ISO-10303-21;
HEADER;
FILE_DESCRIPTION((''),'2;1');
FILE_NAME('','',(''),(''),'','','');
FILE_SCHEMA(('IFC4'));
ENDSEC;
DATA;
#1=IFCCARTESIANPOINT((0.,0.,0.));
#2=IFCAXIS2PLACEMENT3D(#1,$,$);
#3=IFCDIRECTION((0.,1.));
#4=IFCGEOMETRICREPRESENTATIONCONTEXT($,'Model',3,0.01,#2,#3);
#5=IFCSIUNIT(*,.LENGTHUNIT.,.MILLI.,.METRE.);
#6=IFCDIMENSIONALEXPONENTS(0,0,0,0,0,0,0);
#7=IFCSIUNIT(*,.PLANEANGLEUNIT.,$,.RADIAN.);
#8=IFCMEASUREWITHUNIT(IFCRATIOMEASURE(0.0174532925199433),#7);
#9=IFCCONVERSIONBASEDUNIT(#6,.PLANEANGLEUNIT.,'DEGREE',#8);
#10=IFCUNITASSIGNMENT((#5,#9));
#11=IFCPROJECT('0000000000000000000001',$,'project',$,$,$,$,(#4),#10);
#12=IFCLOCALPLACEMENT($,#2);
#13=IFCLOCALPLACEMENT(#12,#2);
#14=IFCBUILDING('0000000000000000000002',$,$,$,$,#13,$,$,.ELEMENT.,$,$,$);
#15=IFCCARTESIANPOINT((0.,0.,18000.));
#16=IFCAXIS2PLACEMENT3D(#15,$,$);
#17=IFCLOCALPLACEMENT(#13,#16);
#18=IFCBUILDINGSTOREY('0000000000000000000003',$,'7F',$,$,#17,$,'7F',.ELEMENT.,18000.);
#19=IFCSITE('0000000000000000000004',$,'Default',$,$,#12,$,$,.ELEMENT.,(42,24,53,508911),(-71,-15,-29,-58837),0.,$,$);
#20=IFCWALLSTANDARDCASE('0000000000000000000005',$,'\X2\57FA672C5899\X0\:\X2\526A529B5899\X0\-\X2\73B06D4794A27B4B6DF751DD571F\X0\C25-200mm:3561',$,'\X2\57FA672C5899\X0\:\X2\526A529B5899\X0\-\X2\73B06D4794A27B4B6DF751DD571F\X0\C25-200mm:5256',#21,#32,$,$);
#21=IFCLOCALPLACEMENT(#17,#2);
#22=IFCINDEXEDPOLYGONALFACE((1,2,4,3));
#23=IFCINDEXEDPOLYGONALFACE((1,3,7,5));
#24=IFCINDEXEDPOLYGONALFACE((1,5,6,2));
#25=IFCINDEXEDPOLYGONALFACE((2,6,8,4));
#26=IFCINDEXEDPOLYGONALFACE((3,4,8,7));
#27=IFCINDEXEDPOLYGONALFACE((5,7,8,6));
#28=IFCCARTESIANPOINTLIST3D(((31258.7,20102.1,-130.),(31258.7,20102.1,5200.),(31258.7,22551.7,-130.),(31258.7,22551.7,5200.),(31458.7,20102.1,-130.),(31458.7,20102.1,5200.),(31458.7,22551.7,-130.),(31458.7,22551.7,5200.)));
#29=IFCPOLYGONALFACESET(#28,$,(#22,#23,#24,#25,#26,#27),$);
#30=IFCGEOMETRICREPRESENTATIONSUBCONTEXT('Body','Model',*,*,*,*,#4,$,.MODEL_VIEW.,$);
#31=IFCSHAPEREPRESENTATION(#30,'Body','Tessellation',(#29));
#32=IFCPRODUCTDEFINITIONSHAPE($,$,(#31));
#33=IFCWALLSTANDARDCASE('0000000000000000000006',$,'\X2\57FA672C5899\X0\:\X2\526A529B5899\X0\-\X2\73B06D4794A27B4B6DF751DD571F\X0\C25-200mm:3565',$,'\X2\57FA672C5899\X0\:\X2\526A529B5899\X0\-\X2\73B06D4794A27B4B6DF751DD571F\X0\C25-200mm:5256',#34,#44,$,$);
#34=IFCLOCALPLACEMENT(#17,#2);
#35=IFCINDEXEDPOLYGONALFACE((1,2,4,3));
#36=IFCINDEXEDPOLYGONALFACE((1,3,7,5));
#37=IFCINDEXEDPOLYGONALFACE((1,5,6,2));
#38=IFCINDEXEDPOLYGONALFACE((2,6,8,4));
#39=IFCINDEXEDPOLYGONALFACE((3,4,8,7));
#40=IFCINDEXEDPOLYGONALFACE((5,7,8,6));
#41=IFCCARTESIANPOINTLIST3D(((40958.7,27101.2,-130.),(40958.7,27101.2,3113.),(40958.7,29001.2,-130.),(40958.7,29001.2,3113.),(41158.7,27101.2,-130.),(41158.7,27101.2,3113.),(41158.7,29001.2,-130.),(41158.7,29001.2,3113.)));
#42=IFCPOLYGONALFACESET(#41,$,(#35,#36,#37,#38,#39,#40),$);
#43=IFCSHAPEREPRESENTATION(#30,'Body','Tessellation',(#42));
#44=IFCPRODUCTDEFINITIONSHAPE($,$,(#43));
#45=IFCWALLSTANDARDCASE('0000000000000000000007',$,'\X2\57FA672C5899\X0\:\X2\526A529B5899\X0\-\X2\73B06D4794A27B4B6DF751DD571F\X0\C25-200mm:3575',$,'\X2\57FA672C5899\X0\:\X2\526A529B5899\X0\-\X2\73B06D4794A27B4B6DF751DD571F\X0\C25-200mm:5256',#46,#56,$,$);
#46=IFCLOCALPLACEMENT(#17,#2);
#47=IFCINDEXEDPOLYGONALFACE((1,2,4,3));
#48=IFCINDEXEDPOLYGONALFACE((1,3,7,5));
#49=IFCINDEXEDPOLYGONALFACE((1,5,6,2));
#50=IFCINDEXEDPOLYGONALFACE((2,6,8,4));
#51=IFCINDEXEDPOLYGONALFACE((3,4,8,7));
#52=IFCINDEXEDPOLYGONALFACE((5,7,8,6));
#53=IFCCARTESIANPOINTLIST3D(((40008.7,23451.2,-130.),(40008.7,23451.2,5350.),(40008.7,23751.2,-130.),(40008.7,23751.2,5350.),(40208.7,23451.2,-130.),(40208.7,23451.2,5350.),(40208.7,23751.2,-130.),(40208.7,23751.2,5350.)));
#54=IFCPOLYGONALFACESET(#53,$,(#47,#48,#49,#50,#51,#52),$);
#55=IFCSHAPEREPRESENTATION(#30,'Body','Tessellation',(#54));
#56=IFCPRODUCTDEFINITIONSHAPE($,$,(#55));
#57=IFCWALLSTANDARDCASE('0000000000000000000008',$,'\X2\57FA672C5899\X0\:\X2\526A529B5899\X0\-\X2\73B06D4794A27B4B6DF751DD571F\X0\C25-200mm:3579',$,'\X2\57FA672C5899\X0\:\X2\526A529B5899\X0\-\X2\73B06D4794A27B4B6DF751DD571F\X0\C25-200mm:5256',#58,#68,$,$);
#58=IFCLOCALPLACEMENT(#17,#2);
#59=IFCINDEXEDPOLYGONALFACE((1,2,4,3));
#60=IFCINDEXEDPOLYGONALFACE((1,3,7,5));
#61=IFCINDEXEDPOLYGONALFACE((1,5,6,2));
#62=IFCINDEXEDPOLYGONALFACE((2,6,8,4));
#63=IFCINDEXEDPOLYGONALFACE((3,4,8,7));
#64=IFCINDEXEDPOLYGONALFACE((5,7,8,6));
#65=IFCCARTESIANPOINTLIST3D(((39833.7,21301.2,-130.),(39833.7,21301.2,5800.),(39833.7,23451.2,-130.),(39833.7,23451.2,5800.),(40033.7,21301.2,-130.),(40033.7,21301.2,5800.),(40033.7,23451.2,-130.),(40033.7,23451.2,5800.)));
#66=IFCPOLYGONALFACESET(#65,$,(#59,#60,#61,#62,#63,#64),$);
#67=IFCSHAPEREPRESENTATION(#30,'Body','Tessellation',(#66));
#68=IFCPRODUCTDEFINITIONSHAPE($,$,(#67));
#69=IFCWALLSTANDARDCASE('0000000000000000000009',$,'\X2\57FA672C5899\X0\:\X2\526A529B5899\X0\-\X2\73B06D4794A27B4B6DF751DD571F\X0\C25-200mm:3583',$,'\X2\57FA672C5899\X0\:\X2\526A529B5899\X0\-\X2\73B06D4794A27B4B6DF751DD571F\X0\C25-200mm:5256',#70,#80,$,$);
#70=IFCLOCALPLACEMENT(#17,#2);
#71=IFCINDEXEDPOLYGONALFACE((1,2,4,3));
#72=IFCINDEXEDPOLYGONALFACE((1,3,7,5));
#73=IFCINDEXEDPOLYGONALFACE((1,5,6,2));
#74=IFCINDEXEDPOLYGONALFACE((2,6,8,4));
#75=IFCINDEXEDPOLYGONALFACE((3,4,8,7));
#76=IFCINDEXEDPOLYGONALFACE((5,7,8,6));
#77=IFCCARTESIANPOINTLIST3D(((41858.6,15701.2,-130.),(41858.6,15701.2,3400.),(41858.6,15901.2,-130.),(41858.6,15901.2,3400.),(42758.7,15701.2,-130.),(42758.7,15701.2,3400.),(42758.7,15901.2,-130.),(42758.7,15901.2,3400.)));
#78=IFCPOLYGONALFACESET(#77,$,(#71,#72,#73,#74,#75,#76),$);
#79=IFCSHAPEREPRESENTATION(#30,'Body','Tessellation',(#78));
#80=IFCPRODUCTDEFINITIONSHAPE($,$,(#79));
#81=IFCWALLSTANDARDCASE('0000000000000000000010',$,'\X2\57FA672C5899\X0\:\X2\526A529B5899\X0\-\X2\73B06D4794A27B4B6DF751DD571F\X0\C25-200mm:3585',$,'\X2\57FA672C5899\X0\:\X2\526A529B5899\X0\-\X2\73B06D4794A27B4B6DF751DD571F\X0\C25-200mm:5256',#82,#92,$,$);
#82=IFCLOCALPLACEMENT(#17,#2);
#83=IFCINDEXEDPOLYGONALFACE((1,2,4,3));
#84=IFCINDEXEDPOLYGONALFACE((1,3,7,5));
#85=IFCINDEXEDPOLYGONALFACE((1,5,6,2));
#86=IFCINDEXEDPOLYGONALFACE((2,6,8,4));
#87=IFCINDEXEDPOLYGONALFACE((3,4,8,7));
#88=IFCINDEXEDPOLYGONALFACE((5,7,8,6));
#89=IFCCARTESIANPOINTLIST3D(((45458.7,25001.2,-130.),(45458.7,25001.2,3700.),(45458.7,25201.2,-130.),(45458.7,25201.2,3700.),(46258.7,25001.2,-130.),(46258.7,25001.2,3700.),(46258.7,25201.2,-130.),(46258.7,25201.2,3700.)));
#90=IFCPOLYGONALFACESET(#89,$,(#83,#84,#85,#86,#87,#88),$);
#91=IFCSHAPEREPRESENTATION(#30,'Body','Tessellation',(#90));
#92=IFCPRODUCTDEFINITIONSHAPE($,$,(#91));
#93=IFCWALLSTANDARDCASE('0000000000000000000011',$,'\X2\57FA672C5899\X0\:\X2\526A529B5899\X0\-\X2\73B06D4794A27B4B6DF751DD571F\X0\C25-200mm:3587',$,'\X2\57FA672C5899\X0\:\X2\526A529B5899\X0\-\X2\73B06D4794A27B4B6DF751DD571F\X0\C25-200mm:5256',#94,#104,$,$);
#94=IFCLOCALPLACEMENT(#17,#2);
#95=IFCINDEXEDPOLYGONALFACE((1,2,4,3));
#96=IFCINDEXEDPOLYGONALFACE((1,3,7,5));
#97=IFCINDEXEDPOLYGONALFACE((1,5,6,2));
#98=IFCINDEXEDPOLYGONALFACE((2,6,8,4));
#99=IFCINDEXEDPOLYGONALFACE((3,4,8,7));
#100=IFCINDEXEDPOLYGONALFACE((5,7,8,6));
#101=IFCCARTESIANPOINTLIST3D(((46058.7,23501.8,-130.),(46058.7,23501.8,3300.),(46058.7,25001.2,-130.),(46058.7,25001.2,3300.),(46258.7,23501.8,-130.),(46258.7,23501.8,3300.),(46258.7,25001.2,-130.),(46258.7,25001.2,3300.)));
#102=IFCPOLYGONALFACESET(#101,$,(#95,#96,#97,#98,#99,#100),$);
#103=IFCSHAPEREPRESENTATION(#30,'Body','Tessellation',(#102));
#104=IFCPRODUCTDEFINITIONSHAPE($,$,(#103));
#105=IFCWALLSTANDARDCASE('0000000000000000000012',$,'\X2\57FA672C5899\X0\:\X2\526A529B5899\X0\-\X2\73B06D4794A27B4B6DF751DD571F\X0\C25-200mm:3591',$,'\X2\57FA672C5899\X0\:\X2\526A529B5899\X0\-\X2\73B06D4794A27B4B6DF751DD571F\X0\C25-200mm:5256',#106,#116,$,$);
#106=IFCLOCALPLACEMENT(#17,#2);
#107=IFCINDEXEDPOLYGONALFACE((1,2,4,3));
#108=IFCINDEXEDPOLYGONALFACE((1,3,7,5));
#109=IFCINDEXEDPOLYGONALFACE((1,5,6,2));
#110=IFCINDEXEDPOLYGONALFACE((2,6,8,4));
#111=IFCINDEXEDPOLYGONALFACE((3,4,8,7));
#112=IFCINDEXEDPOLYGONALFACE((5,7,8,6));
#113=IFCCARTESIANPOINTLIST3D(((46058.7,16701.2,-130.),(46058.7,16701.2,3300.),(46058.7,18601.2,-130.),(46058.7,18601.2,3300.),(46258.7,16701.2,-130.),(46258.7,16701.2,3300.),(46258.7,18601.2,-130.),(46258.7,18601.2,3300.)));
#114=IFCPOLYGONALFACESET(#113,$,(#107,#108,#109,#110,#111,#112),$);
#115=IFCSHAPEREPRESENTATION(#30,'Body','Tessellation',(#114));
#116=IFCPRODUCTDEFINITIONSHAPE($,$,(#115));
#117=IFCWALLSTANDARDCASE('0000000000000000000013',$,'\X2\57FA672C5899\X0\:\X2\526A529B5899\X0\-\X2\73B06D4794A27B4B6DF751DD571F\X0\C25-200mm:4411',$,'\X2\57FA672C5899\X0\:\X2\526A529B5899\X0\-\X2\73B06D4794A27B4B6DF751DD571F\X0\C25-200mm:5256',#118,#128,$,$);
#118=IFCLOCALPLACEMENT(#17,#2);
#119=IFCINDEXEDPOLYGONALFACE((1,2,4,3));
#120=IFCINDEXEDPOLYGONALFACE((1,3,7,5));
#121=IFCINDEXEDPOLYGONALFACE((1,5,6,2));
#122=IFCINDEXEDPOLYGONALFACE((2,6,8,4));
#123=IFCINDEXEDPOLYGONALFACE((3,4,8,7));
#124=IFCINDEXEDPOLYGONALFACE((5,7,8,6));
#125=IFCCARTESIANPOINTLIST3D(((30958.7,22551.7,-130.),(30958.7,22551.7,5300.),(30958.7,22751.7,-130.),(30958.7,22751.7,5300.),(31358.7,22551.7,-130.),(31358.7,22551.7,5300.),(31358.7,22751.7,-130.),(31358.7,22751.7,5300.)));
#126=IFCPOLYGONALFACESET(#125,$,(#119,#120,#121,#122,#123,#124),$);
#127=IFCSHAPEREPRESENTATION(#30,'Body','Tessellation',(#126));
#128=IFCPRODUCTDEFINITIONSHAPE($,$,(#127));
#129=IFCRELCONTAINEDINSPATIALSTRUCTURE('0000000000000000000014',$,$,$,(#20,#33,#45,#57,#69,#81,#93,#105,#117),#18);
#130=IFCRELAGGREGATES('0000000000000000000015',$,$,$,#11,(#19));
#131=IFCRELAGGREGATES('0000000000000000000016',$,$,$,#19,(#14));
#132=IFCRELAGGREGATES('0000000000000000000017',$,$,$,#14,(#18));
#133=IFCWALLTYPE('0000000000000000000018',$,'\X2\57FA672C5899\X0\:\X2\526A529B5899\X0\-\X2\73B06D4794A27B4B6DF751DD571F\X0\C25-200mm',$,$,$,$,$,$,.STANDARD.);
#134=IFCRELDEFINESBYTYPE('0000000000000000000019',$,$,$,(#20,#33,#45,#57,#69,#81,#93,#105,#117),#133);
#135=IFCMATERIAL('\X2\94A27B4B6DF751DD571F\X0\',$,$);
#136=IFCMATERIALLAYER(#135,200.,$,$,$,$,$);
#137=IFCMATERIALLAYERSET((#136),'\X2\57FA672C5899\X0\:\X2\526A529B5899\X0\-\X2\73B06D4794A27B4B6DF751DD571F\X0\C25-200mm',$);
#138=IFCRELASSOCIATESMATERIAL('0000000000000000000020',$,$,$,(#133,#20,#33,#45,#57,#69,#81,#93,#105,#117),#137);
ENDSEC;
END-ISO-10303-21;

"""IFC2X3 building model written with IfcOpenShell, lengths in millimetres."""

from ifc_helpers import new_model, entity, si_unit, converted_unit, direction, frame, frame_2d, origin, place, context, subcontext, project, spatial, rectangle, extrude, material, layer, layer_set, layer_usage, type_object, element, save


model = new_model("IFC2X3")

# Units and contexts
model_context = context("Model", 3, precision=0.01, world=origin(), true_north=direction((0.0, 1.0)))
body_context = subcontext(model_context, "Body", "Model", "MODEL_VIEW")
ifc_project = project(units=[si_unit("LENGTHUNIT", "METRE", prefix="MILLI"), converted_unit("PLANEANGLEUNIT", "DEGREE", entity("IfcRatioMeasure", 0.0174532925199433), si_unit("PLANEANGLEUNIT", "RADIAN"), dimensions=[0, 0, 0, 0, 0, 0, 0])], contexts=[model_context])

# Site, building, storey
site_placement = place(None, origin())
site = spatial("IfcSite", under=ifc_project, at=site_placement, Name="Default", CompositionType="ELEMENT", RefLatitude=(42, 24, 53, 508911), RefLongitude=(-71, -15, -29, -58837), RefElevation=0.0)
building_placement = place(site_placement, origin())
building = spatial("IfcBuilding", under=site, at=building_placement, CompositionType="ELEMENT")
storey_placement = place(building_placement, frame((0.0, 0.0, 18000.0)))
storey = spatial("IfcBuildingStorey", under=building, at=storey_placement, Name="7F", LongName="7F", CompositionType="ELEMENT", Elevation=18000.0)

# Shared definitions
ifc_material = material(Name="钢筋混凝土")

# Shared definitions
ifc_layer = layer(ifc_material, 200.0)
ifc_layer_set = layer_set([ifc_layer], Name="基本墙:剪力墙-现浇钢筋混凝土C25-200mm")
wall_type = type_object("IfcWallType", Name="基本墙:剪力墙-现浇钢筋混凝土C25-200mm", PredefinedType="STANDARD", material=ifc_layer_set)

# Walls
ifc_layer_usage_1 = layer_usage(ifc_layer_set, "AXIS2", "NEGATIVE", 100.0)
wall_1_placement = place(storey_placement, frame((31358.7, 22551.7, -130.0), z_axis=(0.0, 0.0, 1.0), x_axis=(0.0, -1.0, 0.0)))
element("IfcWallStandardCase", 1, at=wall_1_placement, inside=storey, type_object=wall_type, material=ifc_layer_usage_1, Name="基本墙:剪力墙-现浇钢筋混凝土C25-200mm:3561", ObjectType="基本墙:剪力墙-现浇钢筋混凝土C25-200mm:5256", context=body_context, shape_type="SweptSolid", body=[
    extrude(rectangle(XDim=2449.6, YDim=200.0, at=frame_2d((1224.8, 0.0), x_axis=(-1.0, 0.0))), origin(), (0.0, 0.0, 1.0), 5330.0),
])
ifc_layer_usage_2 = layer_usage(ifc_layer_set, "AXIS2", "POSITIVE", -100.0)
wall_2_placement = place(storey_placement, frame((41058.7, 27101.2, -130.0), z_axis=(0.0, 0.0, 1.0), x_axis=(0.0, 1.0, 0.0)))
element("IfcWallStandardCase", 2, at=wall_2_placement, inside=storey, type_object=wall_type, material=ifc_layer_usage_2, Name="基本墙:剪力墙-现浇钢筋混凝土C25-200mm:3565", ObjectType="基本墙:剪力墙-现浇钢筋混凝土C25-200mm:5256", context=body_context, shape_type="SweptSolid", body=[
    extrude(rectangle(XDim=1900.0, YDim=200.0, at=frame_2d((950.0, 0.0), x_axis=(-1.0, 0.0))), origin(), (0.0, 0.0, 1.0), 3243.0),
])
ifc_layer_usage_3 = layer_usage(ifc_layer_set, "AXIS2", "POSITIVE", -100.0)
wall_3_placement = place(storey_placement, frame((40108.7, 23751.2, -130.0), z_axis=(0.0, 0.0, 1.0), x_axis=(0.0, -1.0, 0.0)))
element("IfcWallStandardCase", 3, at=wall_3_placement, inside=storey, type_object=wall_type, material=ifc_layer_usage_3, Name="基本墙:剪力墙-现浇钢筋混凝土C25-200mm:3575", ObjectType="基本墙:剪力墙-现浇钢筋混凝土C25-200mm:5256", context=body_context, shape_type="SweptSolid", body=[
    extrude(rectangle(XDim=300.0, YDim=200.0, at=frame_2d((150.0, 0.0), x_axis=(-1.0, 0.0))), origin(), (0.0, 0.0, 1.0), 5480.0),
])
ifc_layer_usage_4 = layer_usage(ifc_layer_set, "AXIS2", "POSITIVE", -100.0)
wall_4_placement = place(storey_placement, frame((39933.7, 23451.2, -130.0), z_axis=(0.0, 0.0, 1.0), x_axis=(0.0, -1.0, 0.0)))
element("IfcWallStandardCase", 4, at=wall_4_placement, inside=storey, type_object=wall_type, material=ifc_layer_usage_4, Name="基本墙:剪力墙-现浇钢筋混凝土C25-200mm:3579", ObjectType="基本墙:剪力墙-现浇钢筋混凝土C25-200mm:5256", context=body_context, shape_type="SweptSolid", body=[
    extrude(rectangle(XDim=2150.0, YDim=200.0, at=frame_2d((1075.0, 0.0), x_axis=(-1.0, 0.0))), origin(), (0.0, 0.0, 1.0), 5930.0),
])
ifc_layer_usage_5 = layer_usage(ifc_layer_set, "AXIS2", "POSITIVE", -100.0)
wall_5_placement = place(storey_placement, frame((42758.7, 15801.2, -130.0), z_axis=(0.0, 0.0, 1.0), x_axis=(-1.0, 0.0, 0.0)))
element("IfcWallStandardCase", 5, at=wall_5_placement, inside=storey, type_object=wall_type, material=ifc_layer_usage_5, Name="基本墙:剪力墙-现浇钢筋混凝土C25-200mm:3583", ObjectType="基本墙:剪力墙-现浇钢筋混凝土C25-200mm:5256", context=body_context, shape_type="SweptSolid", body=[
    extrude(rectangle(XDim=900.1, YDim=200.0, at=frame_2d((450.0, 0.0), x_axis=(-1.0, 0.0))), origin(), (0.0, 0.0, 1.0), 3530.0),
])
ifc_layer_usage_6 = layer_usage(ifc_layer_set, "AXIS2", "NEGATIVE", 100.0)
wall_6_placement = place(storey_placement, frame((45458.7, 25101.2, -130.0)))
element("IfcWallStandardCase", 6, at=wall_6_placement, inside=storey, type_object=wall_type, material=ifc_layer_usage_6, Name="基本墙:剪力墙-现浇钢筋混凝土C25-200mm:3585", ObjectType="基本墙:剪力墙-现浇钢筋混凝土C25-200mm:5256", context=body_context, shape_type="SweptSolid", body=[
    extrude(rectangle(XDim=800.0, YDim=200.0, at=frame_2d((400.0, 0.0), x_axis=(-1.0, 0.0))), origin(), (0.0, 0.0, 1.0), 3830.0),
])
ifc_layer_usage_7 = layer_usage(ifc_layer_set, "AXIS2", "NEGATIVE", 100.0)
wall_7_placement = place(storey_placement, frame((46158.7, 25001.2, -130.0), z_axis=(0.0, 0.0, 1.0), x_axis=(0.0, -1.0, 0.0)))
element("IfcWallStandardCase", 7, at=wall_7_placement, inside=storey, type_object=wall_type, material=ifc_layer_usage_7, Name="基本墙:剪力墙-现浇钢筋混凝土C25-200mm:3587", ObjectType="基本墙:剪力墙-现浇钢筋混凝土C25-200mm:5256", context=body_context, shape_type="SweptSolid", body=[
    extrude(rectangle(XDim=1499.4, YDim=200.0, at=frame_2d((749.7, 0.0), x_axis=(-1.0, 0.0))), origin(), (0.0, 0.0, 1.0), 3430.0),
])
ifc_layer_usage_8 = layer_usage(ifc_layer_set, "AXIS2", "NEGATIVE", 100.0)
wall_8_placement = place(storey_placement, frame((46158.7, 18601.2, -130.0), z_axis=(0.0, 0.0, 1.0), x_axis=(0.0, -1.0, 0.0)))
element("IfcWallStandardCase", 8, at=wall_8_placement, inside=storey, type_object=wall_type, material=ifc_layer_usage_8, Name="基本墙:剪力墙-现浇钢筋混凝土C25-200mm:3591", ObjectType="基本墙:剪力墙-现浇钢筋混凝土C25-200mm:5256", context=body_context, shape_type="SweptSolid", body=[
    extrude(rectangle(XDim=1900.0, YDim=200.0, at=frame_2d((950.0, 0.0), x_axis=(-1.0, 0.0))), origin(), (0.0, 0.0, 1.0), 3430.0),
])
ifc_layer_usage_9 = layer_usage(ifc_layer_set, "AXIS2", "POSITIVE", -100.0)
wall_9_placement = place(storey_placement, frame((30958.7, 22651.7, -130.0)))
element("IfcWallStandardCase", 9, at=wall_9_placement, inside=storey, type_object=wall_type, material=ifc_layer_usage_9, Name="基本墙:剪力墙-现浇钢筋混凝土C25-200mm:4411", ObjectType="基本墙:剪力墙-现浇钢筋混凝土C25-200mm:5256", context=body_context, shape_type="SweptSolid", body=[
    extrude(rectangle(XDim=400.0, YDim=200.0, at=frame_2d((200.0, 0.0), x_axis=(-1.0, 0.0))), origin(), (0.0, 0.0, 1.0), 5430.0),
])

save(model, "model.ifc")
